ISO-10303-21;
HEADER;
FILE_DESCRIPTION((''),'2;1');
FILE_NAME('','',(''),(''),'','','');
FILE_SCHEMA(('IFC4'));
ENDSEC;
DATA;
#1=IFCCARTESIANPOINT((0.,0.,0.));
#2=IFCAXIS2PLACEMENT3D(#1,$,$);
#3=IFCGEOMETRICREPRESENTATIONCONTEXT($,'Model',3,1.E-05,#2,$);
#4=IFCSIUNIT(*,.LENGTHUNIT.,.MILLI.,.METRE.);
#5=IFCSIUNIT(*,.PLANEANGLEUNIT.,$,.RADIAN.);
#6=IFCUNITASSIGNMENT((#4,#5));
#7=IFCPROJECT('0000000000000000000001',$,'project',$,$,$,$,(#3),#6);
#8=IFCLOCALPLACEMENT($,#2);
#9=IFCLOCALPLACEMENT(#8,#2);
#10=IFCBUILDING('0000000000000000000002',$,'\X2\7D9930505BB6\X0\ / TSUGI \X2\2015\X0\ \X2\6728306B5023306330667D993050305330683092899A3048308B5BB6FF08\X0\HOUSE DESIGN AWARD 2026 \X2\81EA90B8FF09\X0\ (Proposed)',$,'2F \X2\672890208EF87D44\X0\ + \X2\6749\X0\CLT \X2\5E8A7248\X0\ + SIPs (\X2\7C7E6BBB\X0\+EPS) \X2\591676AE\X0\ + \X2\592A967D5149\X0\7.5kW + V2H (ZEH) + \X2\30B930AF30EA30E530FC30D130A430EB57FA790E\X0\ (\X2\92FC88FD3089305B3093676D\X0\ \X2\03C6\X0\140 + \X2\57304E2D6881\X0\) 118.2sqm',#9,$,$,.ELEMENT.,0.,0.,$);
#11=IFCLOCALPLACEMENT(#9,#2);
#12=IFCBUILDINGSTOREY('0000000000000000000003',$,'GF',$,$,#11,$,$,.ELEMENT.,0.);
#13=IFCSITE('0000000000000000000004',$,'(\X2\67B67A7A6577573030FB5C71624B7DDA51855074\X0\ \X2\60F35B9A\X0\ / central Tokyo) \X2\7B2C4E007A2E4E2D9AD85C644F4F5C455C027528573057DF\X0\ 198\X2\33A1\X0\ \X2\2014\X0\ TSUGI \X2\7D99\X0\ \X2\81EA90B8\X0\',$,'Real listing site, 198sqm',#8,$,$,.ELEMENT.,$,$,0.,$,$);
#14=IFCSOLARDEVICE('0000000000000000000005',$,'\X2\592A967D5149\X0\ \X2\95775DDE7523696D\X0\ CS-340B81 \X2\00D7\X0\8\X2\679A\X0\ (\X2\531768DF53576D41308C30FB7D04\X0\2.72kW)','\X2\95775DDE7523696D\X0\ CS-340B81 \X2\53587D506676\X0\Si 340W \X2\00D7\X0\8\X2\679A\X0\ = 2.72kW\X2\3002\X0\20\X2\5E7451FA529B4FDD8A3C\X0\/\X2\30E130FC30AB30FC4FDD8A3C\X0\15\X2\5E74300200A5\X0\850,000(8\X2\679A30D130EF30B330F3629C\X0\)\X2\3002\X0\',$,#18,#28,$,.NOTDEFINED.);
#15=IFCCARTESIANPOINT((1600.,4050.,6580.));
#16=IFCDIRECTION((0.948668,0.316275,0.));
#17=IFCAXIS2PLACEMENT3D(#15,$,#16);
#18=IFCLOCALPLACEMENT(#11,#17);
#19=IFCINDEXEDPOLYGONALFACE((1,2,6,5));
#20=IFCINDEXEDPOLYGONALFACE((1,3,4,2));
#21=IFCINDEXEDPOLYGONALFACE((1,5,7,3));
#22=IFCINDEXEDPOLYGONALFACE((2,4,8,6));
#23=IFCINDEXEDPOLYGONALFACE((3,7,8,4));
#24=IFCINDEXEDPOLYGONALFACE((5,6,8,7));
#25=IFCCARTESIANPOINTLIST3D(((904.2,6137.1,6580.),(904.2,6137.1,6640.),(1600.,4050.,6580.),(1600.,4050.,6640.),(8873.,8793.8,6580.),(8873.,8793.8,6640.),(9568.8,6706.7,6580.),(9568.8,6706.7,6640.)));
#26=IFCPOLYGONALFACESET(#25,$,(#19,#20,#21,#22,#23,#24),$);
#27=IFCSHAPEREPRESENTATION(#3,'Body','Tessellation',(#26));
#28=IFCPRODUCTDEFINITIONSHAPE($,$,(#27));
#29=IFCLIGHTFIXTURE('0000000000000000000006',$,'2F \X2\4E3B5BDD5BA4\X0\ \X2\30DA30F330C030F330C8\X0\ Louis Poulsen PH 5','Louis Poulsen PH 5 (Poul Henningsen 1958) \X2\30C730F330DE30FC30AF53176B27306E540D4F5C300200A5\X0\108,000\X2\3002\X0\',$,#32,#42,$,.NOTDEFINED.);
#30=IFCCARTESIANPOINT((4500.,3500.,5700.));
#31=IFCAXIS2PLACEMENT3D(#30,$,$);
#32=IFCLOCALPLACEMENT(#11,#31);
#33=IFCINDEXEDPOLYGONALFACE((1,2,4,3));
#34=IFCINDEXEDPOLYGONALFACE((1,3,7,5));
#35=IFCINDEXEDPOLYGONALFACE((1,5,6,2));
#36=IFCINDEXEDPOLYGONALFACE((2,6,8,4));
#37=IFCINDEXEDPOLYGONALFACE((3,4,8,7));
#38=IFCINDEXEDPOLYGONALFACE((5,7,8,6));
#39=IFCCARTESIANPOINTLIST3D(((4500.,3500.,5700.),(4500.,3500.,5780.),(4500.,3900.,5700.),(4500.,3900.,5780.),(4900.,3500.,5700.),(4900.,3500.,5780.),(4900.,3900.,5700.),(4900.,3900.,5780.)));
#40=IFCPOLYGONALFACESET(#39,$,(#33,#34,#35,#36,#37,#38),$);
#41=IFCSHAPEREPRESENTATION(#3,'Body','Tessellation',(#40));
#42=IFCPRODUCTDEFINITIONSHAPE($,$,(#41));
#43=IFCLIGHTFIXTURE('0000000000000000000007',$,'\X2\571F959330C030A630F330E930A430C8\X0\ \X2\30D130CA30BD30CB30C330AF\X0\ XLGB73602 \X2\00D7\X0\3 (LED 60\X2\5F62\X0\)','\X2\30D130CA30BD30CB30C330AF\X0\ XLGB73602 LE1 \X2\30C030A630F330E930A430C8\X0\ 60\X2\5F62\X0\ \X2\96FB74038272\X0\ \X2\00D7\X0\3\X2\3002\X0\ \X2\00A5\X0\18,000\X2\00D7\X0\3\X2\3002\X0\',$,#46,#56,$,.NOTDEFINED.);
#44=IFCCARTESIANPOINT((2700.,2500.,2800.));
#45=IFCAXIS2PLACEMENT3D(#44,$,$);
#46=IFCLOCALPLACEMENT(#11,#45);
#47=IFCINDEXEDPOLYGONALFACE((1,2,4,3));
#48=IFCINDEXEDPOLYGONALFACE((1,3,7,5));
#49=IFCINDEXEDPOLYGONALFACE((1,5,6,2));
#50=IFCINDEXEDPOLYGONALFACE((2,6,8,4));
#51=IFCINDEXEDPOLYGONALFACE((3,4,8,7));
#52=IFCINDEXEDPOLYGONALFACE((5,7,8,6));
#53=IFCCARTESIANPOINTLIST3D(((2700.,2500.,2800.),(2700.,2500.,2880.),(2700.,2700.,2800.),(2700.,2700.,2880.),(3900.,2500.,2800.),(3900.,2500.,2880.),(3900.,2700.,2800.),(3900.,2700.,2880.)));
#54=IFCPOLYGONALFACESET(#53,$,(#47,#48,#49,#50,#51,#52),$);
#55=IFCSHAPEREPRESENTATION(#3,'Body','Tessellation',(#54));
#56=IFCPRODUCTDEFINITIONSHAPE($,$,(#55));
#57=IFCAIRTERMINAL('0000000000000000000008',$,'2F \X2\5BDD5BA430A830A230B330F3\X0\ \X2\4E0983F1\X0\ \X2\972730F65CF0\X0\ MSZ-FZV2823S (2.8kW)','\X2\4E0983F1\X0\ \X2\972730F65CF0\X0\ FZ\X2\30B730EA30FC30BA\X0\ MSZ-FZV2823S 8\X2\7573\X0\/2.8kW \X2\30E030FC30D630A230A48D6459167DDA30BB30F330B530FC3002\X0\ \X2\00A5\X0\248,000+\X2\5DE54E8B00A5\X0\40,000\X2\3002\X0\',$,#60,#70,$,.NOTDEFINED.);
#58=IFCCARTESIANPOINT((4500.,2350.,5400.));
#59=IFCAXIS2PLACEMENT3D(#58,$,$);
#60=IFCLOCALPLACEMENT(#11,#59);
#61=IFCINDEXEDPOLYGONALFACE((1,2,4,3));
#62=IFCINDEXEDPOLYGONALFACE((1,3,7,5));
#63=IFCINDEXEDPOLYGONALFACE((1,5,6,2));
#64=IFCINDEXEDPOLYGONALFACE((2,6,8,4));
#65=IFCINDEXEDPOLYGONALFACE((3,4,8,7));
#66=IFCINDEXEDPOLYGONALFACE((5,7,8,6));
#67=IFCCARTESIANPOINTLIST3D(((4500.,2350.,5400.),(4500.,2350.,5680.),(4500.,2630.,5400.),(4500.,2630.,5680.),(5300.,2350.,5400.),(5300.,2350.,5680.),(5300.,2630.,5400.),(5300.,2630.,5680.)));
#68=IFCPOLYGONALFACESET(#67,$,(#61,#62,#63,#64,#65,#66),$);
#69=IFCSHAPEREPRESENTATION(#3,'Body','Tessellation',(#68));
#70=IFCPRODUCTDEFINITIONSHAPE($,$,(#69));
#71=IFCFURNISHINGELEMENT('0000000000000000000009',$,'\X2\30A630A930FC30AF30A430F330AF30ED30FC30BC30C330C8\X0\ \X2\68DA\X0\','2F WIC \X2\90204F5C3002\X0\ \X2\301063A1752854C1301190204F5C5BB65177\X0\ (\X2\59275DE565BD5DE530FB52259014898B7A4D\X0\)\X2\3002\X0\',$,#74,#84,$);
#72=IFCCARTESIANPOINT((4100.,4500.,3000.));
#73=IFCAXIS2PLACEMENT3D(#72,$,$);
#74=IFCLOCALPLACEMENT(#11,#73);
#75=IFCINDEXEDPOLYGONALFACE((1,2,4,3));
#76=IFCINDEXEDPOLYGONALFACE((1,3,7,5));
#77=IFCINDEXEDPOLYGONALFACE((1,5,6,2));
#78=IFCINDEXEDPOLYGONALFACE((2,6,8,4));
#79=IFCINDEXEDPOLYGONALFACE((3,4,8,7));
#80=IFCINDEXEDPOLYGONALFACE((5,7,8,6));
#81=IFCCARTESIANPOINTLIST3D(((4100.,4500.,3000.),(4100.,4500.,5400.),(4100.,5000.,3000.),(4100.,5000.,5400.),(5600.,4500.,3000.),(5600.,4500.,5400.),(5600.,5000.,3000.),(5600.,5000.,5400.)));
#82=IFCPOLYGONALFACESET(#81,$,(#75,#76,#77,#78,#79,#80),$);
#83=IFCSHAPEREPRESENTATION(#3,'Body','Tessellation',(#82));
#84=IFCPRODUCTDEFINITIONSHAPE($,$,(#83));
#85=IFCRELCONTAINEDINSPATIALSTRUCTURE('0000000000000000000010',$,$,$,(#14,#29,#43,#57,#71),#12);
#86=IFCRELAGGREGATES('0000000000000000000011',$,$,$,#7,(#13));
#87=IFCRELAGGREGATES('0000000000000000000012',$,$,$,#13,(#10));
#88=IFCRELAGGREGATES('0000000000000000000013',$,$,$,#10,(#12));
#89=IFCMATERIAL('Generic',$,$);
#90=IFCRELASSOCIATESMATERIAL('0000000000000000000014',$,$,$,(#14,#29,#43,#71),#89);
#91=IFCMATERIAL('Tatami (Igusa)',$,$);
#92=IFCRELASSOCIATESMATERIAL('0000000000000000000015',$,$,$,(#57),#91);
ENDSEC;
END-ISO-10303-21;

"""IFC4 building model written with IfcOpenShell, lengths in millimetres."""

from ifc_helpers import new_model, si_unit, frame, frame_2d, origin, place, context, project, spatial, rectangle, extrude, material, element, save


model = new_model("IFC4")

# Units and contexts
model_context = context("Model", 3, precision=1e-05, world=origin())
ifc_project = project(units=[si_unit("LENGTHUNIT", "METRE", prefix="MILLI"), si_unit("PLANEANGLEUNIT", "RADIAN")], contexts=[model_context])

# Site, building, storey
site_placement = place(None, origin())
site = spatial("IfcSite", under=ifc_project, at=site_placement, Name="(架空敷地・山手線内側 想定 / central Tokyo) 第一種中高層住居専用地域 198㎡ — TSUGI 継 自邸", ObjectType="Real listing site, 198sqm", CompositionType="ELEMENT", RefElevation=0.0)
building_placement = place(site_placement, origin())
building = spatial("IfcBuilding", under=site, at=building_placement, Name="継ぐ家 / TSUGI ― 木に倣って継ぐことを覚える家（HOUSE DESIGN AWARD 2026 自邸） (Proposed)", ObjectType="2F 木造軸組 + 杉CLT 床版 + SIPs (籾殻+EPS) 外皮 + 太陽光7.5kW + V2H (ZEH) + スクリューパイル基礎 (鋼製らせん杭 φ140 + 地中梁) 118.2sqm", CompositionType="ELEMENT", ElevationOfRefHeight=0.0, ElevationOfTerrain=0.0)
storey_placement = place(building_placement, origin())
storey = spatial("IfcBuildingStorey", under=building, at=storey_placement, Name="GF", CompositionType="ELEMENT", Elevation=0.0)

# Shared definitions
ifc_material_1 = material(Name="Generic")

# Solar device
solar_device_placement = place(storey_placement, frame((1600.0, 4050.0, 6580.0), x_axis=(0.948668, 0.316275, 0.0)))
element("IfcSolarDevice", 1, at=solar_device_placement, inside=storey, material=ifc_material_1, Name="太陽光 長州産業 CS-340B81 ×8枚 (北棟南流れ・約2.72kW)", Description="長州産業 CS-340B81 単結晶Si 340W ×8枚 = 2.72kW。20年出力保証/メーカー保証15年。¥850,000(8枚パワコン抜)。", PredefinedType="NOTDEFINED", context=model_context, shape_type="SweptSolid", body=[
    extrude(rectangle(XDim=8400.0, YDim=2200.0, at=frame_2d((4200.0, 1100.0))), frame((1600.0, 4050.0, 6580.0), x_axis=(0.948668, 0.316275, 0.0)), (0.0, 0.0, 1.0), 60.0),
])

# Light fixtures
light_fixture_1_placement = place(storey_placement, frame((4500.0, 3500.0, 5700.0)))
element("IfcLightFixture", 2, at=light_fixture_1_placement, inside=storey, material=ifc_material_1, Name="2F 主寝室 ペンダント Louis Poulsen PH 5", Description="Louis Poulsen PH 5 (Poul Henningsen 1958) デンマーク北欧の名作。¥108,000。", PredefinedType="NOTDEFINED", context=model_context, shape_type="SweptSolid", body=[
    extrude(rectangle(XDim=400.0, YDim=400.0, at=frame_2d((200.0, 200.0))), frame((4500.0, 3500.0, 5700.0)), (0.0, 0.0, 1.0), 80.0),
])
light_fixture_2_placement = place(storey_placement, frame((2700.0, 2500.0, 2800.0)))
element("IfcLightFixture", 3, at=light_fixture_2_placement, inside=storey, material=ifc_material_1, Name="土間ダウンライト パナソニック XLGB73602 ×3 (LED 60形)", Description="パナソニック XLGB73602 LE1 ダウンライト 60形 電球色 ×3。 ¥18,000×3。", PredefinedType="NOTDEFINED", context=model_context, shape_type="SweptSolid", body=[
    extrude(rectangle(XDim=1200.0, YDim=200.0, at=frame_2d((600.0, 100.0))), frame((2700.0, 2500.0, 2800.0)), (0.0, 0.0, 1.0), 80.0),
])

# Air terminal
ifc_material_2 = material(Name="Tatami (Igusa)")
air_terminal_placement = place(storey_placement, frame((4500.0, 2350.0, 5400.0)))
element("IfcAirTerminal", 4, at=air_terminal_placement, inside=storey, material=ifc_material_2, Name="2F 寝室エアコン 三菱 霧ヶ峰 MSZ-FZV2823S (2.8kW)", Description="三菱 霧ヶ峰 FZシリーズ MSZ-FZV2823S 8畳/2.8kW ムーブアイ赤外線センサー。 ¥248,000+工事¥40,000。", PredefinedType="NOTDEFINED", context=model_context, shape_type="SweptSolid", body=[
    extrude(rectangle(XDim=800.0, YDim=280.0, at=frame_2d((400.0, 140.0))), frame((4500.0, 2350.0, 5400.0)), (0.0, 0.0, 1.0), 280.0),
])

# Furnishing element
furnishing_placement = place(storey_placement, frame((4100.0, 4500.0, 3000.0)))
element("IfcFurnishingElement", 5, at=furnishing_placement, inside=storey, material=ifc_material_1, Name="ウォークインクローゼット 棚", Description="2F WIC 造作。 【採用品】造作家具 (大工施工・別途見積)。", context=model_context, shape_type="SweptSolid", body=[
    extrude(rectangle(XDim=1500.0, YDim=500.0, at=frame_2d((750.0, 250.0))), frame((4100.0, 4500.0, 3000.0)), (0.0, 0.0, 1.0), 2400.0),
])

save(model, "model.ifc")
